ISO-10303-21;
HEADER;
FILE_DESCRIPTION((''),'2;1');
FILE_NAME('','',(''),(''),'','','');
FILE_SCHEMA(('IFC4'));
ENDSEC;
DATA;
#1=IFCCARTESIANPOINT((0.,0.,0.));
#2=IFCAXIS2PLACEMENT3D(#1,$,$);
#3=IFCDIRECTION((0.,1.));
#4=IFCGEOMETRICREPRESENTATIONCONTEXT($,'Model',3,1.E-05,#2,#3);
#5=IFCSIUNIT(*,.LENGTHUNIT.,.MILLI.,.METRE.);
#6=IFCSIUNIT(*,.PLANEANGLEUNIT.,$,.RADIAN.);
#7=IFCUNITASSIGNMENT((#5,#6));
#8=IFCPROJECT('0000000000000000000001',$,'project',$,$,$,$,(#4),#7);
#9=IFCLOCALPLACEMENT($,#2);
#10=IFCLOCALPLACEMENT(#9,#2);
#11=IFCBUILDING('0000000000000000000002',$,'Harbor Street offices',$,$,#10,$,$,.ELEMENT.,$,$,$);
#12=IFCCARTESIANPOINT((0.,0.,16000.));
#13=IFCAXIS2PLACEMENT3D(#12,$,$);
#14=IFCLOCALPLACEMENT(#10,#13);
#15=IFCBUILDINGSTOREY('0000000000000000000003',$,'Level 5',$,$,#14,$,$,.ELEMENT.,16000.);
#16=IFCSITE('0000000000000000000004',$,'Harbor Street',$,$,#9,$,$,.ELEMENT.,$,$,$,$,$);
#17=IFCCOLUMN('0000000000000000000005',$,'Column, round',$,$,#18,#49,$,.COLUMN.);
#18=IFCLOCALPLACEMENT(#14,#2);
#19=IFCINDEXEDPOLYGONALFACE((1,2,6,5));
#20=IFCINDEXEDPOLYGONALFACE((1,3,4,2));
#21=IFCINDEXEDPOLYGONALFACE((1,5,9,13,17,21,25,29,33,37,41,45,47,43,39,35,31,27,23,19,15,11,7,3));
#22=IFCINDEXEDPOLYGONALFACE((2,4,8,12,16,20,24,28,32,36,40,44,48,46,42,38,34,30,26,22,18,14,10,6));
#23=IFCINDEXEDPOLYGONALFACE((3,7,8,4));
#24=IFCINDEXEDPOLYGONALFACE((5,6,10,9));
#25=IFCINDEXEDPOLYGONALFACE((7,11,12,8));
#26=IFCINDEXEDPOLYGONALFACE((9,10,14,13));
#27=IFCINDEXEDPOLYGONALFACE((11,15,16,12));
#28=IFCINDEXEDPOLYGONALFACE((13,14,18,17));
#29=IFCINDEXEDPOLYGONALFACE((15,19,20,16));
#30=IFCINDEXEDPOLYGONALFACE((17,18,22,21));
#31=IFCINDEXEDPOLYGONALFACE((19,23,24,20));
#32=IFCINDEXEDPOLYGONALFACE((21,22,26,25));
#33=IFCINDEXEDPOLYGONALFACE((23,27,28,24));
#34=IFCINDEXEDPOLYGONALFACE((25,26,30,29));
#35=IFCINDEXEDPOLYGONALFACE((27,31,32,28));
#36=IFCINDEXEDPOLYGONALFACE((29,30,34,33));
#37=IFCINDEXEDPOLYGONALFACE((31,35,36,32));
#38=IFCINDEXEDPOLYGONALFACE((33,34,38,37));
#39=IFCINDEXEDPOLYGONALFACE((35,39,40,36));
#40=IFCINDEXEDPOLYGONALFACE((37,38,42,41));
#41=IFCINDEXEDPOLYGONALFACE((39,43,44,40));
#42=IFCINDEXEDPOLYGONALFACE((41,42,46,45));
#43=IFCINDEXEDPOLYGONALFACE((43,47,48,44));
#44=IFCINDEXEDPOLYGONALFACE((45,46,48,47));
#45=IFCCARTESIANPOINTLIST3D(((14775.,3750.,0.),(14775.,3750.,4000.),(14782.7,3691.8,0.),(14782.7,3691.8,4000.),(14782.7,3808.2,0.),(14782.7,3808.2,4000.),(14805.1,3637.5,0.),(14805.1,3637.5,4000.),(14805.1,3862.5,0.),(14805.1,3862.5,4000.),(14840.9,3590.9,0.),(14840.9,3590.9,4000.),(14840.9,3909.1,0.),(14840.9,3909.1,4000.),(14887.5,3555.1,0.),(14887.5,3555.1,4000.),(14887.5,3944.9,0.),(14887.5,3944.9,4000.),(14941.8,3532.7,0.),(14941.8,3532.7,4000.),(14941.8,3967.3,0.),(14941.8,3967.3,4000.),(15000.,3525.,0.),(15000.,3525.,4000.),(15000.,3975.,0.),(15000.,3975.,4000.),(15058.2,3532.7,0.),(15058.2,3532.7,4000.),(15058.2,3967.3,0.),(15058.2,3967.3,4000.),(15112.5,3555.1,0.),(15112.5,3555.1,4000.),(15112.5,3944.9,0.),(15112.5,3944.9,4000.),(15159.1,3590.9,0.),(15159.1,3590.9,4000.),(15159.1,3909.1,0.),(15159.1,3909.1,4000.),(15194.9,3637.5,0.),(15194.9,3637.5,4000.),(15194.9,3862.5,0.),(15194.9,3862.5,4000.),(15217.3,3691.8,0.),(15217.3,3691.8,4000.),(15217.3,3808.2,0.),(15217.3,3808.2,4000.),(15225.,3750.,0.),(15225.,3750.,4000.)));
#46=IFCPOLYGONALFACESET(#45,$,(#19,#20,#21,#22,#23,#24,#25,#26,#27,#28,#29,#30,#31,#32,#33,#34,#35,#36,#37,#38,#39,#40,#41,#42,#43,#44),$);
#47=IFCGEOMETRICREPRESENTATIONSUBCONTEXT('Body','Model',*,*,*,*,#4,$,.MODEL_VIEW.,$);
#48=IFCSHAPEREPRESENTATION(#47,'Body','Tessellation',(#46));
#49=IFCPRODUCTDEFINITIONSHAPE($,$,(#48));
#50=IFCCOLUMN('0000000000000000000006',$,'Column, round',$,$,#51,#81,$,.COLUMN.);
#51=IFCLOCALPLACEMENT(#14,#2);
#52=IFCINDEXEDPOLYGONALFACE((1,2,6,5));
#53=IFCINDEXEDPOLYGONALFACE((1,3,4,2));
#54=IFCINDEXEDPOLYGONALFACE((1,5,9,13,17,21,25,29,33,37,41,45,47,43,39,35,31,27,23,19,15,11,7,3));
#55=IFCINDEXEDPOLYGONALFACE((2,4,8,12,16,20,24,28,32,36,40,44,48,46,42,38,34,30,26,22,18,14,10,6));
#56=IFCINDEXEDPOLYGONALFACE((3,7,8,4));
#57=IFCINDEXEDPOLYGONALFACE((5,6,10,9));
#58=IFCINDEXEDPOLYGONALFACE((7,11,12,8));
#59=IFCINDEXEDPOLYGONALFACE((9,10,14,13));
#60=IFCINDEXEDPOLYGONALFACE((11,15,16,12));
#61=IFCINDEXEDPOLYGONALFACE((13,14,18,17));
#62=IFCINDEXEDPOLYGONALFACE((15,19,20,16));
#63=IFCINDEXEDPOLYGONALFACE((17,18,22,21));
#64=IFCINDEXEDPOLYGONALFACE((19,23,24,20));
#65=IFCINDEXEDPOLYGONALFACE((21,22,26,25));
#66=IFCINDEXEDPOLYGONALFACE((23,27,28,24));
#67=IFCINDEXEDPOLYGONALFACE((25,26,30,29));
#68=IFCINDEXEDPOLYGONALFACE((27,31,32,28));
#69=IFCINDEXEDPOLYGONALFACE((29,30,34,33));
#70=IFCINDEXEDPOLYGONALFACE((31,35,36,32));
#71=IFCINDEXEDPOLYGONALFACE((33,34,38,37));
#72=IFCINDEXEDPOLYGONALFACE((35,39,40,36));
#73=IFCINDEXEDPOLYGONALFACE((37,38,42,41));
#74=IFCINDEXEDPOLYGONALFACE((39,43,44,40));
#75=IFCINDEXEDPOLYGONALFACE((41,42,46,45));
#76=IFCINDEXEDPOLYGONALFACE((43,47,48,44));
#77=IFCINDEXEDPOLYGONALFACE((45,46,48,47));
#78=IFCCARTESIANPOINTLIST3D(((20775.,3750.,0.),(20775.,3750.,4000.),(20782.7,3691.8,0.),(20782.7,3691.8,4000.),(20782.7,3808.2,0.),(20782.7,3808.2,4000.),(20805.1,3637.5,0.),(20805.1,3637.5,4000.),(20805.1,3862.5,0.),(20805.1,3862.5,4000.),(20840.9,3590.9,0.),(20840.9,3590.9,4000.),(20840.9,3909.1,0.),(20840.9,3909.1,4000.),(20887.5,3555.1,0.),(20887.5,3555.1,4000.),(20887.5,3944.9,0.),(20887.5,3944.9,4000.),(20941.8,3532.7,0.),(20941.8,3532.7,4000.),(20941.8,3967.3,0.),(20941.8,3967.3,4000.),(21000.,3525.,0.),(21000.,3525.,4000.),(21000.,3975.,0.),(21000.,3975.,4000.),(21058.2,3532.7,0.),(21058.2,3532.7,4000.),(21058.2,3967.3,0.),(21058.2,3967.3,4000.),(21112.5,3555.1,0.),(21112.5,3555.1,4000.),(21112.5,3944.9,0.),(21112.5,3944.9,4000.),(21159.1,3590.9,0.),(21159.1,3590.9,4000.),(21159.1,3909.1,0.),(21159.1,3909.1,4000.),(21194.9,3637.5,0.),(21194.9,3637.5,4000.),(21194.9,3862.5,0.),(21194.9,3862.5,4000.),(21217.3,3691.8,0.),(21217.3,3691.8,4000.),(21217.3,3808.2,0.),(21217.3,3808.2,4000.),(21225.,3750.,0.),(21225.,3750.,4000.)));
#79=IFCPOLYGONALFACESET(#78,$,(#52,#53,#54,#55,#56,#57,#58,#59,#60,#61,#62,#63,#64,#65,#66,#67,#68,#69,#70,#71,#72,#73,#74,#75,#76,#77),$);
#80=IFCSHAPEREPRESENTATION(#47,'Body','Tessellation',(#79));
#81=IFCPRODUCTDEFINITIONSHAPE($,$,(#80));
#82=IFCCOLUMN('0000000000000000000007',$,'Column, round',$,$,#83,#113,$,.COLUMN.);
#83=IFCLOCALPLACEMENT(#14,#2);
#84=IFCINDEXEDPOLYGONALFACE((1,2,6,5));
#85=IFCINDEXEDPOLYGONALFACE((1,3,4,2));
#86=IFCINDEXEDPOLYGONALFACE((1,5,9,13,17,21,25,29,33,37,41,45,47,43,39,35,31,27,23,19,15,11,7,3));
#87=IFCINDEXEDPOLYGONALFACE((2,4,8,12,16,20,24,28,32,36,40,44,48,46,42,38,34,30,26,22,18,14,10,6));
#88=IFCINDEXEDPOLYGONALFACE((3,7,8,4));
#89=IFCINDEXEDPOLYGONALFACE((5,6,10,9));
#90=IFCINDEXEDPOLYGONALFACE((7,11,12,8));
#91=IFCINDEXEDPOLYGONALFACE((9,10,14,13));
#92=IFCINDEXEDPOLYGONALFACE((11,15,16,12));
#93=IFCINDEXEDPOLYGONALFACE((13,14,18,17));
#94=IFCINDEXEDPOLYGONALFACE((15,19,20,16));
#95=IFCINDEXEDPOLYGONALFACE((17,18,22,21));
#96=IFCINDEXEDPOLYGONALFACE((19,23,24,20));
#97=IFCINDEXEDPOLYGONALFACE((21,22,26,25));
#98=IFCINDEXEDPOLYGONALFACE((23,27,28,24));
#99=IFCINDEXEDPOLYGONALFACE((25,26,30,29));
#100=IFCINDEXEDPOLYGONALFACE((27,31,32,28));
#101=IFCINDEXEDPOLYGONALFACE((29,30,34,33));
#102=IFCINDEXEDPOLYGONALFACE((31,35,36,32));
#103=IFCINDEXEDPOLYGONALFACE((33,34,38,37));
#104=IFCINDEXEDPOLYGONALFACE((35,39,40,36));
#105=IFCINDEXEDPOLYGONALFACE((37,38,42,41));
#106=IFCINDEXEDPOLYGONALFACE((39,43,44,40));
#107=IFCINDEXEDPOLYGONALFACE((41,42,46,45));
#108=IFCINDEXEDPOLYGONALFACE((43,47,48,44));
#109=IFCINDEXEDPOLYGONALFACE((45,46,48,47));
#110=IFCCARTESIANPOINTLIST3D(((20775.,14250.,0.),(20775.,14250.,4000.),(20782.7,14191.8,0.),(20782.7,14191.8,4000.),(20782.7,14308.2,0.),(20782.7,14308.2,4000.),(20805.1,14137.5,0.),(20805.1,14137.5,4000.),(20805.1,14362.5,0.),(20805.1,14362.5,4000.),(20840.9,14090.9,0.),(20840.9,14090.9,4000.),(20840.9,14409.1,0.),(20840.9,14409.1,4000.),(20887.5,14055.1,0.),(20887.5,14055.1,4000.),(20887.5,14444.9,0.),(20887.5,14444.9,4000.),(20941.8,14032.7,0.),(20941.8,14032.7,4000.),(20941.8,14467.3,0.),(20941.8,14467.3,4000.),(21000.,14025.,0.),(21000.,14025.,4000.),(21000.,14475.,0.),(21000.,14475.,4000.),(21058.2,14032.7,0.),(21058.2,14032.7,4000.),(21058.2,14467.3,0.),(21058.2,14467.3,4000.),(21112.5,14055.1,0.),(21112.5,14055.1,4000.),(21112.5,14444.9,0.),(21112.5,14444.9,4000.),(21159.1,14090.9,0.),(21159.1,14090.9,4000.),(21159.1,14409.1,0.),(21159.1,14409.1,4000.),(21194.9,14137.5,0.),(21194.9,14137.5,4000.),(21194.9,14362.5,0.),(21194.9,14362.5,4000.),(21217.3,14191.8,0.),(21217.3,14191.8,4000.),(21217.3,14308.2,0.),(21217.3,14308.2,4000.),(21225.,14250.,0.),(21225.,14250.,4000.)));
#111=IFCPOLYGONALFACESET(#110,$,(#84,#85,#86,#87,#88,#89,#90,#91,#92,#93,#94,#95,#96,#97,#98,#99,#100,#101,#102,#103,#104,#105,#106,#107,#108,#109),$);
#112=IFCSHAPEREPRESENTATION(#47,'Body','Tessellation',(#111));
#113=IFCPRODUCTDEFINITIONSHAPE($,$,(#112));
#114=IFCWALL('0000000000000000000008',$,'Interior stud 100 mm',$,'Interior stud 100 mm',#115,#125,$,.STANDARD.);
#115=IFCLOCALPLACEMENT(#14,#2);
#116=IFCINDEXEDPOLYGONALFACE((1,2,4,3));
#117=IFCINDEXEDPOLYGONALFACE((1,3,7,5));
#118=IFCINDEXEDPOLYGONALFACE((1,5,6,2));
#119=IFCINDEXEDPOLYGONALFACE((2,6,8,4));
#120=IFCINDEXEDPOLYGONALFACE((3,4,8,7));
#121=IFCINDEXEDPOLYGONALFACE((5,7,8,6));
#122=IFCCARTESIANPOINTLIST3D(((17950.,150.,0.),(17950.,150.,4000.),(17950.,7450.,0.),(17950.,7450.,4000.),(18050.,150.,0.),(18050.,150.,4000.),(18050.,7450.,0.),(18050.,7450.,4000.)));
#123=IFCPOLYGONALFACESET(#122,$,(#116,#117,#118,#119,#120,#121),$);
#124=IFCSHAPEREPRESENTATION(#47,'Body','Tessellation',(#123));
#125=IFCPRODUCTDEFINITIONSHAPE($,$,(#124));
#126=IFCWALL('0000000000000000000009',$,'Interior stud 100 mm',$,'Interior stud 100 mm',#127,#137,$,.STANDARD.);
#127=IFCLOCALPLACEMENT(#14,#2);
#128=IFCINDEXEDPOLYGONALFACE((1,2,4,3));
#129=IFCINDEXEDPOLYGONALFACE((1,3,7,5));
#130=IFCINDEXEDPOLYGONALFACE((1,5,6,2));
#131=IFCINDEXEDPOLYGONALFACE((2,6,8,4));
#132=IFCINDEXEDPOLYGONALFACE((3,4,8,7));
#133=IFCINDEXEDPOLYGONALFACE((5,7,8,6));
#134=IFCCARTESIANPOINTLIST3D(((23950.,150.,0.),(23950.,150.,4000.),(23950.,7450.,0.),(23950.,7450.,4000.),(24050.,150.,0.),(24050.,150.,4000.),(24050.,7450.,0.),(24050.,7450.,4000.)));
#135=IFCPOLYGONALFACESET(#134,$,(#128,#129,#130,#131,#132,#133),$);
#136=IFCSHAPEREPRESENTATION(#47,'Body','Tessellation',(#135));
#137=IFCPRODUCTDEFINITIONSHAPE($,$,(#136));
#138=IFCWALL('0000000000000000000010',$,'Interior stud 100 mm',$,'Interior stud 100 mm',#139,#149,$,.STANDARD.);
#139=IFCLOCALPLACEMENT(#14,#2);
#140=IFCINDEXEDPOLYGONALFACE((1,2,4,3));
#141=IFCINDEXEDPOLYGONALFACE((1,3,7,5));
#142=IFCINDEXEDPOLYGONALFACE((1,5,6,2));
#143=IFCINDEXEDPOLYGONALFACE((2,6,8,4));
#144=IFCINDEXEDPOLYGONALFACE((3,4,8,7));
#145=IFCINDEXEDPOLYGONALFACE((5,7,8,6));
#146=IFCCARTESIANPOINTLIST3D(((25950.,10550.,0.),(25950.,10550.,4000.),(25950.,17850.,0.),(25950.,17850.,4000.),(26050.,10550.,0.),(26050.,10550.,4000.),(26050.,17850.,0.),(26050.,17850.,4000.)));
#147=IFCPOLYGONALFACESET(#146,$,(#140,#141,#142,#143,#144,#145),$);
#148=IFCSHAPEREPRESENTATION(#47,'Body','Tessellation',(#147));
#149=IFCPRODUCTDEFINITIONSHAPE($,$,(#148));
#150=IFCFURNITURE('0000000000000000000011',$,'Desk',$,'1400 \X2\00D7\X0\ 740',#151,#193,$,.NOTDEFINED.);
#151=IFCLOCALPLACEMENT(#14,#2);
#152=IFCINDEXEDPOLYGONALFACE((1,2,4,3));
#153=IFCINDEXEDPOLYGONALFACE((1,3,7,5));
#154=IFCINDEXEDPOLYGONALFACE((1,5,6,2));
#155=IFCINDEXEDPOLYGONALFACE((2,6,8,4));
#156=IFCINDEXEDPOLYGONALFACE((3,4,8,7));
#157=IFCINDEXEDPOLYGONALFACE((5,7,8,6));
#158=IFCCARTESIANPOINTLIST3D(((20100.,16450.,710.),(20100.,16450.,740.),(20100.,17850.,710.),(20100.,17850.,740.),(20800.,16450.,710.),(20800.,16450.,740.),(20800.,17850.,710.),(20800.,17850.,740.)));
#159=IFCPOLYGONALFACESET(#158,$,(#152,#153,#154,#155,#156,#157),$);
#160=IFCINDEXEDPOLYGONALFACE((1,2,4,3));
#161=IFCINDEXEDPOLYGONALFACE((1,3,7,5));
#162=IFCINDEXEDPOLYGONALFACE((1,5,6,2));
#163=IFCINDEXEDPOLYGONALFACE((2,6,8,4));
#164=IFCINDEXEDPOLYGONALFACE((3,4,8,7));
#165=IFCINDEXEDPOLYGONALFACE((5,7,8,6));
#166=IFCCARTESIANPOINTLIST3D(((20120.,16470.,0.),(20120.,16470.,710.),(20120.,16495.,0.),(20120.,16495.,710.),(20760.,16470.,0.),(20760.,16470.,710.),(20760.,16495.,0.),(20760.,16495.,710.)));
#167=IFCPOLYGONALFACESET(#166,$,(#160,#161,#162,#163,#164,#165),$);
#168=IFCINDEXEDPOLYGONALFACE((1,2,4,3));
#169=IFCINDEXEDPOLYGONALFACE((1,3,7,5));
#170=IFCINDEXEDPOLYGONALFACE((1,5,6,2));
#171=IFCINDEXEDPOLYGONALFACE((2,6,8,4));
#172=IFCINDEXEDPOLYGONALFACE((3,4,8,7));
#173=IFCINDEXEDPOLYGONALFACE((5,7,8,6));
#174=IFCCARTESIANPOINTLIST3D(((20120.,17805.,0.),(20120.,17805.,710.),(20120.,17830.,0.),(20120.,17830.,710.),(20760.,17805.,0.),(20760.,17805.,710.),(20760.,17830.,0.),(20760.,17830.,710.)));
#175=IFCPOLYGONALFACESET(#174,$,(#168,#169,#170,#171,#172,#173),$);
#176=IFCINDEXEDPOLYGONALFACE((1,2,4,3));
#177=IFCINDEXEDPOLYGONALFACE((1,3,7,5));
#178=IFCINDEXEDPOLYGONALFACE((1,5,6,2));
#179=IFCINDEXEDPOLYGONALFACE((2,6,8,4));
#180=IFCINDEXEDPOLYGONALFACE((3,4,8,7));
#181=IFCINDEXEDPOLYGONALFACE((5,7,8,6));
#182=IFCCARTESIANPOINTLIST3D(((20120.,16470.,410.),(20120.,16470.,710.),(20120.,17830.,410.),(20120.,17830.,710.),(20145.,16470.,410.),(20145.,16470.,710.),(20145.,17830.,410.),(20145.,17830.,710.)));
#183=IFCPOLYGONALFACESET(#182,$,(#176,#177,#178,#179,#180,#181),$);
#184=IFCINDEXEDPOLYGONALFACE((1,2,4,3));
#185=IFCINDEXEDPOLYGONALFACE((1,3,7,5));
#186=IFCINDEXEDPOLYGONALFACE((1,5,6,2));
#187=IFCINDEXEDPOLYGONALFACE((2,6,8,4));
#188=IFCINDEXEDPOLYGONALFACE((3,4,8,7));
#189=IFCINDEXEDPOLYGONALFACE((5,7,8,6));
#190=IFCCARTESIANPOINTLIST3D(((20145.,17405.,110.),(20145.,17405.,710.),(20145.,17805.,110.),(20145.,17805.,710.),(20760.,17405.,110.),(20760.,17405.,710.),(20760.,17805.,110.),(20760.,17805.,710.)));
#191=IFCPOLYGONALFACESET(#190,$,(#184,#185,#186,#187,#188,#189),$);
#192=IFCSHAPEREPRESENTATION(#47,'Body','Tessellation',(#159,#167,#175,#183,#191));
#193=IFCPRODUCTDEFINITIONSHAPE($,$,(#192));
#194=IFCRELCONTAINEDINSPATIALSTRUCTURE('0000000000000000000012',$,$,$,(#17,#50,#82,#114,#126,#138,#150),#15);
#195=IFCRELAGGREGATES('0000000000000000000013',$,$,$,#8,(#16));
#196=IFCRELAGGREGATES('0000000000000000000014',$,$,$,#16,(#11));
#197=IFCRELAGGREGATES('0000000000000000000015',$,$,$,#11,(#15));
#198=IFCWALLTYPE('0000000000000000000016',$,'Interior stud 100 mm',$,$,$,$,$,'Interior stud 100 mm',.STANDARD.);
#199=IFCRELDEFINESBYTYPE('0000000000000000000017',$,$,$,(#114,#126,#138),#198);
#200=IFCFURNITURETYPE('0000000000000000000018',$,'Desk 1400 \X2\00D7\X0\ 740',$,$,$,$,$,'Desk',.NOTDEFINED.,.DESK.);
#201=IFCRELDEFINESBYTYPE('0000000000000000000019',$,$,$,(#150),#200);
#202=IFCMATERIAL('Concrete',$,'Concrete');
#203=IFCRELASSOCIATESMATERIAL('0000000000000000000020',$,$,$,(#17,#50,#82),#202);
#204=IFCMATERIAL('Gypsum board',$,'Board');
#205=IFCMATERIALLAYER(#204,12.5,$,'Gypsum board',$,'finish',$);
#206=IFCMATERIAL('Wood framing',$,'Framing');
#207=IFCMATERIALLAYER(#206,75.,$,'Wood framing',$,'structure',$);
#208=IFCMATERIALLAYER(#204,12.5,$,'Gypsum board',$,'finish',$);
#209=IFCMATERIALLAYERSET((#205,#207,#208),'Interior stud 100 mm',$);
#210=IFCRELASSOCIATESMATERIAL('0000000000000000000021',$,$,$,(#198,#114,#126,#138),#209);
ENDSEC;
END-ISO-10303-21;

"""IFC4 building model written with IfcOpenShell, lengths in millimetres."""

from ifc_helpers import new_model, si_unit, direction, frame, origin, origin_2d, place, context, subcontext, project, spatial, polyline, circle, outline, extrude, source, transform, mapped, material, layer, layer_set, layer_usage, type_object, type_shapes, element, save


model = new_model("IFC4")

# Units and contexts
model_context = context("Model", 3, precision=1e-05, world=origin(), true_north=direction((0.0, 1.0)))
body_context = subcontext(model_context, "Body", "Model", "MODEL_VIEW")
ifc_project = project(units=[si_unit("LENGTHUNIT", "METRE", prefix="MILLI"), si_unit("PLANEANGLEUNIT", "RADIAN")], contexts=[model_context])

# Site, building, storey
site_placement = place(None, origin())
site = spatial("IfcSite", under=ifc_project, at=site_placement, Name="Harbor Street", CompositionType="ELEMENT")
building_placement = place(site_placement, origin())
building = spatial("IfcBuilding", under=site, at=building_placement, Name="Harbor Street offices", CompositionType="ELEMENT")
storey_placement = place(building_placement, frame((0.0, 0.0, 16000.0)))
storey = spatial("IfcBuildingStorey", under=building, at=storey_placement, Name="Level 5", CompositionType="ELEMENT", Elevation=16000.0)

# Columns
ifc_material_1 = material(Name="Concrete", Category="Concrete")
for number, where, z_axis, x_axis, name in (
    (1, (15000.0, 3750.0, 0.0), (0.0, 0.0, 1.0), (1.0, 0.0, 0.0), "Column, round"),
    (2, (21000.0, 3750.0, 0.0), (0.0, 0.0, 1.0), (1.0, 0.0, 0.0), "Column, round"),
    (3, (21000.0, 14250.0, 0.0), (0.0, 0.0, 1.0), (1.0, 0.0, 0.0), "Column, round"),
):
    element("IfcColumn", number, at=place(storey_placement, frame(where, z_axis=z_axis, x_axis=x_axis)), inside=storey, material=ifc_material_1, Name=name, PredefinedType="COLUMN", context=body_context, shape_type="SweptSolid", body=[
        extrude(circle(Radius=225.0, at=origin_2d()), origin(), (0.0, 0.0, 1.0), 4000.0),
    ])

# Walls
ifc_material_2 = material(Name="Gypsum board", Category="Board")
ifc_layer_1 = layer(ifc_material_2, 12.5, Name="Gypsum board", Category="finish")
ifc_material_3 = material(Name="Wood framing", Category="Framing")
ifc_layer_2 = layer(ifc_material_3, 75.0, Name="Wood framing", Category="structure")
ifc_layer_3 = layer(ifc_material_2, 12.5, Name="Gypsum board", Category="finish")
ifc_layer_set_1 = layer_set([ifc_layer_1, ifc_layer_2, ifc_layer_3], Name="Interior stud 100 mm")
ifc_layer_usage_1 = layer_usage(ifc_layer_set_1, "AXIS2", "NEGATIVE", 50.0)
wall_type_1 = type_object("IfcWallType", Name="Interior stud 100 mm", ElementType="Interior stud 100 mm", PredefinedType="STANDARD", material=ifc_layer_set_1)
wall_1_placement = place(storey_placement, frame((18000.0, 0.0, 0.0), z_axis=(0.0, 0.0, 1.0), x_axis=(0.0, 1.0, 0.0)))
element("IfcWall", 4, at=wall_1_placement, inside=storey, type_object=wall_type_1, material=ifc_layer_usage_1, Name="Interior stud 100 mm", ObjectType="Interior stud 100 mm", PredefinedType="STANDARD", context=body_context, shape_type="SweptSolid", body=[
    extrude(outline(polyline([(150.0, -50.0), (7450.0, -50.0), (7450.0, 50.0), (150.0, 50.0), (150.0, -50.0)])), origin(), (0.0, 0.0, 1.0), 4000.0),
])
ifc_layer_usage_2 = layer_usage(ifc_layer_set_1, "AXIS2", "NEGATIVE", 50.0)
wall_2_placement = place(storey_placement, frame((24000.0, 0.0, 0.0), z_axis=(0.0, 0.0, 1.0), x_axis=(0.0, 1.0, 0.0)))
element("IfcWall", 5, at=wall_2_placement, inside=storey, type_object=wall_type_1, material=ifc_layer_usage_2, Name="Interior stud 100 mm", ObjectType="Interior stud 100 mm", PredefinedType="STANDARD", context=body_context, shape_type="SweptSolid", body=[
    extrude(outline(polyline([(150.0, -50.0), (7450.0, -50.0), (7450.0, 50.0), (150.0, 50.0), (150.0, -50.0)])), origin(), (0.0, 0.0, 1.0), 4000.0),
])
ifc_layer_usage_3 = layer_usage(ifc_layer_set_1, "AXIS2", "NEGATIVE", 50.0)
wall_3_placement = place(storey_placement, frame((26000.0, 10500.0, 0.0), z_axis=(0.0, 0.0, 1.0), x_axis=(0.0, 1.0, 0.0)))
element("IfcWall", 6, at=wall_3_placement, inside=storey, type_object=wall_type_1, material=ifc_layer_usage_3, Name="Interior stud 100 mm", ObjectType="Interior stud 100 mm", PredefinedType="STANDARD", context=body_context, shape_type="SweptSolid", body=[
    extrude(outline(polyline([(50.0, -50.0), (7350.0, -50.0), (7350.0, 50.0), (50.0, 50.0), (50.0, -50.0)])), origin(), (0.0, 0.0, 1.0), 4000.0),
])

# Furniture
furniture_type_1 = type_object("IfcFurnitureType", Name="Desk 1400 × 740", ElementType="Desk", AssemblyPlace="NOTDEFINED", PredefinedType="DESK")
shared_shape_1 = source(origin(), body_context, "Body", "SweptSolid", [
    extrude(outline(polyline([(-700.0, 0.0), (700.0, 0.0), (700.0, 700.0), (-700.0, 700.0), (-700.0, 0.0)])), frame((0.0, 0.0, 710.0)), (0.0, 0.0, 1.0), 30.0),
    extrude(outline(polyline([(-680.0, 40.0), (-655.0, 40.0), (-655.0, 680.0), (-680.0, 680.0), (-680.0, 40.0)])), origin(), (0.0, 0.0, 1.0), 710.0),
    extrude(outline(polyline([(655.0, 40.0), (680.0, 40.0), (680.0, 680.0), (655.0, 680.0), (655.0, 40.0)])), origin(), (0.0, 0.0, 1.0), 710.0),
    extrude(outline(polyline([(-680.0, 655.0), (680.0, 655.0), (680.0, 680.0), (-680.0, 680.0), (-680.0, 655.0)])), frame((0.0, 0.0, 410.0)), (0.0, 0.0, 1.0), 300.0),
    extrude(outline(polyline([(255.0, 40.0), (655.0, 40.0), (655.0, 655.0), (255.0, 655.0), (255.0, 40.0)])), frame((0.0, 0.0, 110.0)), (0.0, 0.0, 1.0), 600.0),
])
type_shapes(furniture_type_1, [shared_shape_1])
for number, where, z_axis, x_axis, name in (
    (7, (20800.0, 17150.0, 0.0), (0.0, 0.0, 1.0), (0.0, 1.0, 0.0), "Desk"),
):
    element("IfcFurniture", number, at=place(storey_placement, frame(where, z_axis=z_axis, x_axis=x_axis)), inside=storey, type_object=furniture_type_1, Name=name, ObjectType="1400 × 740", PredefinedType="NOTDEFINED", context=body_context, shape_type="MappedRepresentation", body=[
        mapped(shared_shape_1, transform((0.0, 0.0, 0.0))),
    ])

save(model, "model.ifc")
